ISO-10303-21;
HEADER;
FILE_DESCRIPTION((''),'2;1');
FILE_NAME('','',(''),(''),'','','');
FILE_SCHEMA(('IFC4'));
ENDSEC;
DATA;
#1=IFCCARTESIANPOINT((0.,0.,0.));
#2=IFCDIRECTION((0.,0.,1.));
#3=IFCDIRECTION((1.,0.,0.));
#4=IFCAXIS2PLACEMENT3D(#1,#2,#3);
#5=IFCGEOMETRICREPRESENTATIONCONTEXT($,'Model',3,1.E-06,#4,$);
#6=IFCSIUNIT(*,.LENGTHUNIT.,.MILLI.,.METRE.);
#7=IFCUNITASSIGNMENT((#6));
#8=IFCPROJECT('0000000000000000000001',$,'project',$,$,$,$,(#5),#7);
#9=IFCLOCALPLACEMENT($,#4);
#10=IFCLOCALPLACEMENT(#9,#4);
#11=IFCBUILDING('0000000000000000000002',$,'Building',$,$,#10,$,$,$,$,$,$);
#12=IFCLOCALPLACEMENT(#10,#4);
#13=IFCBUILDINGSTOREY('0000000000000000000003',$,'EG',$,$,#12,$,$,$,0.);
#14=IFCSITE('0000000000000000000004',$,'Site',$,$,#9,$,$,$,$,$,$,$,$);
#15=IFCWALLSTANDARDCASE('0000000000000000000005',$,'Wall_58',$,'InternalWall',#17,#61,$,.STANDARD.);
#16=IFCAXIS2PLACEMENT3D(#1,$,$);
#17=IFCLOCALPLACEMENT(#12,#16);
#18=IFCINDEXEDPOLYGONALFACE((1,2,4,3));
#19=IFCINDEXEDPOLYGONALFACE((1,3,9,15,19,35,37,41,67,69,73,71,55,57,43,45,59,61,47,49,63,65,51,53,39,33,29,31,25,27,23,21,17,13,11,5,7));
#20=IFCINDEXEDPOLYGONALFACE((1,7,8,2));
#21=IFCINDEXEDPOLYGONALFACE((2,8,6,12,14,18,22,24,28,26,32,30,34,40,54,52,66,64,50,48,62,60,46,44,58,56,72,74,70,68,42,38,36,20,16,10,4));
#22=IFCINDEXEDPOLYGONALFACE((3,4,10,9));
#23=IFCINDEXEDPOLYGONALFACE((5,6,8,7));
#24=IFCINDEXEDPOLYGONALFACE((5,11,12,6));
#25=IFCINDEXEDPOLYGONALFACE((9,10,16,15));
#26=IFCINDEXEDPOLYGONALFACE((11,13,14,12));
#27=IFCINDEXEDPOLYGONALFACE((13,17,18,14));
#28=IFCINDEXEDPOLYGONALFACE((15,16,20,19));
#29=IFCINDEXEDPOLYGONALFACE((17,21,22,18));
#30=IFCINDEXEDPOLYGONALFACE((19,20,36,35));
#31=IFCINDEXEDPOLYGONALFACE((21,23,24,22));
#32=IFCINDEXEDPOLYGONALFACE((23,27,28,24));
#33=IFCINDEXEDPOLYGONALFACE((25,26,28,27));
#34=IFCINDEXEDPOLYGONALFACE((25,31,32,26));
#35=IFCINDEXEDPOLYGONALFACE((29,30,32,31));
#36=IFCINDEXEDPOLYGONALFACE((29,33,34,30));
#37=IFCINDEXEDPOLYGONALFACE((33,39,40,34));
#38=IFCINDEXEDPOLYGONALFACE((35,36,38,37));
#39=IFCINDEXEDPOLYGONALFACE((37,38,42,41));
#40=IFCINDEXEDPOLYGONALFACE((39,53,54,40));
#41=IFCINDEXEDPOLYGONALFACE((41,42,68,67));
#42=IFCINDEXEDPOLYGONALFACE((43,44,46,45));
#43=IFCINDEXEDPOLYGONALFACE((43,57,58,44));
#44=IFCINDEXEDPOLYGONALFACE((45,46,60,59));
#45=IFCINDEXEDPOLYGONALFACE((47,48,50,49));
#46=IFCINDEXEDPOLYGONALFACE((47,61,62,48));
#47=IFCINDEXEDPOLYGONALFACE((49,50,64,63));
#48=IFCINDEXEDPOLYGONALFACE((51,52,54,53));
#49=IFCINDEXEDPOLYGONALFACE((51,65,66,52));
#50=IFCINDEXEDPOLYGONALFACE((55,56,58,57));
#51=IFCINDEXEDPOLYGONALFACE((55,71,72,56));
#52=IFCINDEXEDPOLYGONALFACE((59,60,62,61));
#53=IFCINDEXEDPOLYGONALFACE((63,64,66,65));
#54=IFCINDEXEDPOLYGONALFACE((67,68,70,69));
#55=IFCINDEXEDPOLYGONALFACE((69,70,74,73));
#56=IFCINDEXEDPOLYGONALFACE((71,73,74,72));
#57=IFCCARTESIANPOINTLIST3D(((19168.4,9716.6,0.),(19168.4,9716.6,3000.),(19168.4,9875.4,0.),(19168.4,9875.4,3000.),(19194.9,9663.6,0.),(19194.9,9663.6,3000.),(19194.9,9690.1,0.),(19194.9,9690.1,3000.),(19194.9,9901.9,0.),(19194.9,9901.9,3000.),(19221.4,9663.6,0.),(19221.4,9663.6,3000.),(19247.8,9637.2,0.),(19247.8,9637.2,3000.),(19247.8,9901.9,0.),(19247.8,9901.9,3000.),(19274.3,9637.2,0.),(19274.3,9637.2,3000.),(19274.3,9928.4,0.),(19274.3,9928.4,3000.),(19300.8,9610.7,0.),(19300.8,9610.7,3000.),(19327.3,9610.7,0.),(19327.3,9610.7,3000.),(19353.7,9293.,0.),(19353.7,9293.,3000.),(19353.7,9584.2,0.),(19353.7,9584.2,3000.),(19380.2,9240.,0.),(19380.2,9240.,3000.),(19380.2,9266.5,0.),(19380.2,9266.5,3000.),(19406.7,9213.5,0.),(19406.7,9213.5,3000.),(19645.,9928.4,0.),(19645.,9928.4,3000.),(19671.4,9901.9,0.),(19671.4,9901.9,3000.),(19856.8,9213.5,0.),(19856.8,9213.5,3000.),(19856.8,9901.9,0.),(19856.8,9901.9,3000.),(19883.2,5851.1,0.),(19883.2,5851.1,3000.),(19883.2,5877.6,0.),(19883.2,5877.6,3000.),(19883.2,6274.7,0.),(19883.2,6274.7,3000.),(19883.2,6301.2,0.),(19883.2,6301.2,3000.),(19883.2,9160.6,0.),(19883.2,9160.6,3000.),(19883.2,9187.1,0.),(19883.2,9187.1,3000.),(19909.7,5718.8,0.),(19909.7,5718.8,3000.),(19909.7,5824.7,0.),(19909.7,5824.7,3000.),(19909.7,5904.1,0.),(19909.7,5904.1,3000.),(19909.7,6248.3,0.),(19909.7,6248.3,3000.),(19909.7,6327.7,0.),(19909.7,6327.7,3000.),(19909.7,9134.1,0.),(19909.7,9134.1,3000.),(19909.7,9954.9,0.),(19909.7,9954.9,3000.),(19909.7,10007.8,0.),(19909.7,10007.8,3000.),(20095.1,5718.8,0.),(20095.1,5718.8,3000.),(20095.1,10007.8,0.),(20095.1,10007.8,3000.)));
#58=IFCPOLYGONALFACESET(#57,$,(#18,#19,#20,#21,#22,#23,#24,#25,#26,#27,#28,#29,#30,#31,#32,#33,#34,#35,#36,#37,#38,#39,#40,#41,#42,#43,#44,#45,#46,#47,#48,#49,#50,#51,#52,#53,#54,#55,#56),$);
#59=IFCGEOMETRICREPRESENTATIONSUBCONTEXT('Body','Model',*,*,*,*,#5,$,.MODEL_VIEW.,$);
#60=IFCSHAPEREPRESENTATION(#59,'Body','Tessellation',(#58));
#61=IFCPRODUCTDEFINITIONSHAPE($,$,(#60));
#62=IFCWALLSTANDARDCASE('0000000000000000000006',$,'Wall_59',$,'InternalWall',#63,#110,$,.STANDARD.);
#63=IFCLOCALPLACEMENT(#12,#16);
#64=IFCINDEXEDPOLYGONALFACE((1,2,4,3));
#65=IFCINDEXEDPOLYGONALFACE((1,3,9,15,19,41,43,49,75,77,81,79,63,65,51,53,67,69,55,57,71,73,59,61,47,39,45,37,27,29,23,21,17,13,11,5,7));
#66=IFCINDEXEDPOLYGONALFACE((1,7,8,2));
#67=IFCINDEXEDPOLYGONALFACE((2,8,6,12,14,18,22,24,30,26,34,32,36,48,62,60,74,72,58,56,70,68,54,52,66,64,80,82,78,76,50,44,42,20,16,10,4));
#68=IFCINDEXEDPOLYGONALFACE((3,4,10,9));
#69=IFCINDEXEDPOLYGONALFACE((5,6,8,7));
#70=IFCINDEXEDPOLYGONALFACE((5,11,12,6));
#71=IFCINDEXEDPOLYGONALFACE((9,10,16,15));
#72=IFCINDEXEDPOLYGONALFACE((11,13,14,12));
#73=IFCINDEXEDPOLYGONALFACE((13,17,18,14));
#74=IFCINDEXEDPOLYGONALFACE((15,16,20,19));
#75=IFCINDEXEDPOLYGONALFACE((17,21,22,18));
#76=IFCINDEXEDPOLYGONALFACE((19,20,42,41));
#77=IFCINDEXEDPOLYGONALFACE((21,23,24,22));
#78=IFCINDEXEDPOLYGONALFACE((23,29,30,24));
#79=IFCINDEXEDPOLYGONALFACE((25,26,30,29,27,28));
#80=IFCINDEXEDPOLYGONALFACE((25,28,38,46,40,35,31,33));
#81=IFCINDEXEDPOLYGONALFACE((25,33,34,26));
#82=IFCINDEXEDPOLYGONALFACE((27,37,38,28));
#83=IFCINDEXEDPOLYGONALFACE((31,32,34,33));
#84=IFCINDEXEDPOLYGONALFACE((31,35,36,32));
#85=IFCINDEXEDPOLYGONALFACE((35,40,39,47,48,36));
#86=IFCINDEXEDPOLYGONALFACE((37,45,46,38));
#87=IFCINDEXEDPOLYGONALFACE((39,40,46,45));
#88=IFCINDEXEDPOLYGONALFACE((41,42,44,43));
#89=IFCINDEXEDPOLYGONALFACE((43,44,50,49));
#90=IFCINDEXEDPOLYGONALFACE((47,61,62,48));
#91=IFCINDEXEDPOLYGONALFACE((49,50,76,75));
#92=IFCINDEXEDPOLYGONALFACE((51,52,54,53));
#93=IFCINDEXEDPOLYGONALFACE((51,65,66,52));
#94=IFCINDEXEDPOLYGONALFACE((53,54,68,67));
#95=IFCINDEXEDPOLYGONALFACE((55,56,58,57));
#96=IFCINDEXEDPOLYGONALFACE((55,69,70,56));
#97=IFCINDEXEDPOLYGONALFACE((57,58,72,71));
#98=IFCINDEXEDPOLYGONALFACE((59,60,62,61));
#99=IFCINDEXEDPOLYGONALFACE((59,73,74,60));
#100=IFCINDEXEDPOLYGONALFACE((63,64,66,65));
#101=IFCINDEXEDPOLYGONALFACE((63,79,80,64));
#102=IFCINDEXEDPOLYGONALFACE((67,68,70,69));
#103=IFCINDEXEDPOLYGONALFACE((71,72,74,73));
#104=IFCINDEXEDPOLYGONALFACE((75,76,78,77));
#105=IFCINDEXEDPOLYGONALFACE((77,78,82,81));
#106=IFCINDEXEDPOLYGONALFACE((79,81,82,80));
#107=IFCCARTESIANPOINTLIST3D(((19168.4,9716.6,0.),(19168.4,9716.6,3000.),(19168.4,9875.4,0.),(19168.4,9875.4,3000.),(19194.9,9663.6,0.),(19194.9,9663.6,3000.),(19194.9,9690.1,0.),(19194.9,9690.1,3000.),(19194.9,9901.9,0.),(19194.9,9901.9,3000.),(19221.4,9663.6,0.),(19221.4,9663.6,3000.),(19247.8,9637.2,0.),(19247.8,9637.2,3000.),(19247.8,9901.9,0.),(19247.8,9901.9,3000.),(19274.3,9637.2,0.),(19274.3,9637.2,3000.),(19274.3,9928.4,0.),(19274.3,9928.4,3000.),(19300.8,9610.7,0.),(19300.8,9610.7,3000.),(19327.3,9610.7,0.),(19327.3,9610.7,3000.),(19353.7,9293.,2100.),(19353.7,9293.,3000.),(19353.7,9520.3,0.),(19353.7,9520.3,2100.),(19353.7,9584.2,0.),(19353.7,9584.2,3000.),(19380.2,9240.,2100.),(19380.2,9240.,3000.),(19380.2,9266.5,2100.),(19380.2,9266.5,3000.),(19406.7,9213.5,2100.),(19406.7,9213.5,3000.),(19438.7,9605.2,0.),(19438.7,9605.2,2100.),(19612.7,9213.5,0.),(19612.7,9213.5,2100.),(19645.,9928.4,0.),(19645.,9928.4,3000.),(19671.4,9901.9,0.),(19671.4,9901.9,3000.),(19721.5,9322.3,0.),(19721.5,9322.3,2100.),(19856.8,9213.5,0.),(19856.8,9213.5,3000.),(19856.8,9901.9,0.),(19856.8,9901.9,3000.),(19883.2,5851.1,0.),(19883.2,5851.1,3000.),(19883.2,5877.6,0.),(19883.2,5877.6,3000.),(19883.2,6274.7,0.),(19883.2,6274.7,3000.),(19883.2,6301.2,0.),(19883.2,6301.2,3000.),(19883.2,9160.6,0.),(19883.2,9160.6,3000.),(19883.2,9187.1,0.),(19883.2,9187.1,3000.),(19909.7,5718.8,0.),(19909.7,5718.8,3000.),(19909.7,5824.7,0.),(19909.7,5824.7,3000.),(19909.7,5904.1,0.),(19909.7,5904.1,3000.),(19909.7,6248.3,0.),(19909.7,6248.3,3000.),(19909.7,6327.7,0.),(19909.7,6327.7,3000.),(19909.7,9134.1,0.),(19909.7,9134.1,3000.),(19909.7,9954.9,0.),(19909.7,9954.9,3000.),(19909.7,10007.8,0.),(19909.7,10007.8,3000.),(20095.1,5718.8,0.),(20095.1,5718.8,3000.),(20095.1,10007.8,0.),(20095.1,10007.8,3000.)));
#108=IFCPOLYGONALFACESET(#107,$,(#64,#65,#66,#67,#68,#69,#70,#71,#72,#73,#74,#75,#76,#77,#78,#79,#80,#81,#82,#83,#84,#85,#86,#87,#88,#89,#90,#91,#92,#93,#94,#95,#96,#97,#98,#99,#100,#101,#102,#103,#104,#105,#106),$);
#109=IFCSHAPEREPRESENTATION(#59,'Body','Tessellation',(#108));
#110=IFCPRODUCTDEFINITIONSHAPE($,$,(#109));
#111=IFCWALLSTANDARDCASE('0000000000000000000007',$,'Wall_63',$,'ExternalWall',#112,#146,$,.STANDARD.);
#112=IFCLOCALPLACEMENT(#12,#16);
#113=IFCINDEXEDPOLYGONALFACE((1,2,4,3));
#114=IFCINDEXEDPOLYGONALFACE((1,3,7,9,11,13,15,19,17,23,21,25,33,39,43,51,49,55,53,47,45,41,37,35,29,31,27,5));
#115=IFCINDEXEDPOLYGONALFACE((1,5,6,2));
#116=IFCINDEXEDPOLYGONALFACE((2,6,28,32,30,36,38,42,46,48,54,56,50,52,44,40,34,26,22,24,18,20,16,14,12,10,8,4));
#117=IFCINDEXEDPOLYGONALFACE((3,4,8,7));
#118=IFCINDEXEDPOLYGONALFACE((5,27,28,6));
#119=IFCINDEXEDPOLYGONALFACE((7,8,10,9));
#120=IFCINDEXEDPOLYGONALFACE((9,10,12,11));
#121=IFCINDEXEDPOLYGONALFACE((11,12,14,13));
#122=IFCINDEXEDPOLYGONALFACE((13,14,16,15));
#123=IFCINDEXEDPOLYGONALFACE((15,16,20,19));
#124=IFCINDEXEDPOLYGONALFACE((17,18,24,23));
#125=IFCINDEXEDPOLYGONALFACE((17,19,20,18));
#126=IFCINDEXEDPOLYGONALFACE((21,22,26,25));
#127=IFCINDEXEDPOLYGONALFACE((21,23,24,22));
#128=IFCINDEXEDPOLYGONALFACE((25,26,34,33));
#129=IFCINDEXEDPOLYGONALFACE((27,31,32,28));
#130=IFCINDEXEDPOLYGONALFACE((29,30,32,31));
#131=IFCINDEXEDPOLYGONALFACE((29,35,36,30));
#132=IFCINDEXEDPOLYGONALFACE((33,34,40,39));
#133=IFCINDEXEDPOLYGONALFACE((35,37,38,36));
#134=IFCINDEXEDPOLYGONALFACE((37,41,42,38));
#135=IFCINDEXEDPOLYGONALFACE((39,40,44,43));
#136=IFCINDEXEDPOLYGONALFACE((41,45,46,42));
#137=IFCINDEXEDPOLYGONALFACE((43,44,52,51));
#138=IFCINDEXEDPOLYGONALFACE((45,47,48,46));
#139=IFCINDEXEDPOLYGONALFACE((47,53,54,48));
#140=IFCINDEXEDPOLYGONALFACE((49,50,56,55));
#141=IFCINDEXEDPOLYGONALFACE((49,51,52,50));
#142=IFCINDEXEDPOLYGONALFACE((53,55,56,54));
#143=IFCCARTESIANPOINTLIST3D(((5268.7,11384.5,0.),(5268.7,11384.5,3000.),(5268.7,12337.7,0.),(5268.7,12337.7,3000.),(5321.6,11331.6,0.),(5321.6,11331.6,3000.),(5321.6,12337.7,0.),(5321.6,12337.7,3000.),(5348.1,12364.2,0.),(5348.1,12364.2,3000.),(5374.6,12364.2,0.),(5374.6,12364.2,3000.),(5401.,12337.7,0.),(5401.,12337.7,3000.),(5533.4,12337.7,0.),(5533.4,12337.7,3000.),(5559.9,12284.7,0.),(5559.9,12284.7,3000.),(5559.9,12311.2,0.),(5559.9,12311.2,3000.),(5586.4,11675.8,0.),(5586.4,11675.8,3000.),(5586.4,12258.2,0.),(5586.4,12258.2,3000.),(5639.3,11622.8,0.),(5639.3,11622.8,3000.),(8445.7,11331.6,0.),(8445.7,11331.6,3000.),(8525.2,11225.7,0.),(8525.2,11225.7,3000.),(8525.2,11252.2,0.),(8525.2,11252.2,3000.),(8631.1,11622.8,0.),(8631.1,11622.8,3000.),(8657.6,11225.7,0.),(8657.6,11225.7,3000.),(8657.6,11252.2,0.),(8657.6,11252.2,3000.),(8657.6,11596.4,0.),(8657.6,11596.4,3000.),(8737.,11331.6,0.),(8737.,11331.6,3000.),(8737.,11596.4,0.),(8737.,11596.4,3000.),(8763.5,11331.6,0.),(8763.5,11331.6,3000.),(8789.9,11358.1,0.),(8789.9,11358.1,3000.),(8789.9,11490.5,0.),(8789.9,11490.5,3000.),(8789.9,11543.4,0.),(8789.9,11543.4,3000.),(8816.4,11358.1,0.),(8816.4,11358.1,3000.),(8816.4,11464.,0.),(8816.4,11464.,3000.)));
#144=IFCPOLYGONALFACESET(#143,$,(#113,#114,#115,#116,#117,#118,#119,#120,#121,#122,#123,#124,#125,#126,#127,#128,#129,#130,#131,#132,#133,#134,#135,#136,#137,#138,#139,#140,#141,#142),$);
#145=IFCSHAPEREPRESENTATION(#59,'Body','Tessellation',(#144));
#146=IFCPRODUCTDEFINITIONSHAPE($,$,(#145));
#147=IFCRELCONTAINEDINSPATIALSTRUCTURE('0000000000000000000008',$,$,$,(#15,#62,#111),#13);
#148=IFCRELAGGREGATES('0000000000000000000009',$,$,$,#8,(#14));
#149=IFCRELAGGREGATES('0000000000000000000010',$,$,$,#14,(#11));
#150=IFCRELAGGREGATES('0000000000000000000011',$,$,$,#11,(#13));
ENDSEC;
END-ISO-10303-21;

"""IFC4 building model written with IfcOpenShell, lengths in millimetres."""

from ifc_helpers import new_model, si_unit, frame, origin_with_axes, place, context, subcontext, project, spatial, polyline, rectangle, outline, extrude, element, save


model = new_model("IFC4")

# Units and contexts
model_context = context("Model", 3, precision=1e-06, world=origin_with_axes())
body_context = subcontext(model_context, "Body", "Model", "MODEL_VIEW")
ifc_project = project(units=[si_unit("LENGTHUNIT", "METRE", prefix="MILLI")], contexts=[model_context])

# Site, building, storey
site_placement = place(None, origin_with_axes())
site = spatial("IfcSite", under=ifc_project, at=site_placement, Name="Site")
building_placement = place(site_placement, origin_with_axes())
building = spatial("IfcBuilding", under=site, at=building_placement, Name="Building")
storey_placement = place(building_placement, origin_with_axes())
storey = spatial("IfcBuildingStorey", under=building, at=storey_placement, Name="EG", Elevation=0.0)

# Wall
wall_1_placement = place(storey_placement, origin_with_axes())
element("IfcWallStandardCase", 1, at=wall_1_placement, inside=storey, Name="Wall_58", ObjectType="InternalWall", PredefinedType="STANDARD", context=body_context, shape_type="SweptSolid", body=[
    extrude(outline(polyline([(19909.7, 5718.8, 0.0), (19909.7, 5824.7, 0.0), (19883.2, 5851.1, 0.0), (19883.2, 5877.6, 0.0), (19909.7, 5904.1, 0.0), (19909.7, 6248.3, 0.0), (19883.2, 6274.7, 0.0), (19883.2, 6301.2, 0.0), (19909.7, 6327.7, 0.0), (19909.7, 9134.1, 0.0), (19883.2, 9160.6, 0.0), (19883.2, 9187.1, 0.0), (19856.8, 9213.5, 0.0), (19406.7, 9213.5, 0.0), (19380.2, 9240.0, 0.0), (19380.2, 9266.5, 0.0), (19353.7, 9293.0, 0.0), (19353.7, 9584.2, 0.0), (19327.3, 9610.7, 0.0), (19300.8, 9610.7, 0.0), (19274.3, 9637.2, 0.0), (19247.8, 9637.2, 0.0), (19221.4, 9663.6, 0.0), (19194.9, 9663.6, 0.0), (19194.9, 9690.1, 0.0), (19168.4, 9716.6, 0.0), (19168.4, 9875.4, 0.0), (19194.9, 9901.9, 0.0), (19247.8, 9901.9, 0.0), (19274.3, 9928.4, 0.0), (19645.0, 9928.4, 0.0), (19671.4, 9901.9, 0.0), (19856.8, 9901.9, 0.0), (19909.7, 9954.9, 0.0), (19909.7, 10007.8, 0.0), (20095.1, 10007.8, 0.0), (20095.1, 5718.8, 0.0), (19909.7, 5718.8, 0.0)])), origin_with_axes(), (0.0, 0.0, 1.0), 3000.0),
])

# Wall, opening
wall_2_placement = place(storey_placement, origin_with_axes())
wall_2 = element("IfcWallStandardCase", 2, at=wall_2_placement, inside=storey, Name="Wall_59", ObjectType="InternalWall", PredefinedType="STANDARD", context=body_context, shape_type="SweptSolid", body=[
    extrude(outline(polyline([(19909.7, 5718.8, 0.0), (19909.7, 5824.7, 0.0), (19883.2, 5851.1, 0.0), (19883.2, 5877.6, 0.0), (19909.7, 5904.1, 0.0), (19909.7, 6248.3, 0.0), (19883.2, 6274.7, 0.0), (19883.2, 6301.2, 0.0), (19909.7, 6327.7, 0.0), (19909.7, 9134.1, 0.0), (19883.2, 9160.6, 0.0), (19883.2, 9187.1, 0.0), (19856.8, 9213.5, 0.0), (19406.7, 9213.5, 0.0), (19380.2, 9240.0, 0.0), (19380.2, 9266.5, 0.0), (19353.7, 9293.0, 0.0), (19353.7, 9584.2, 0.0), (19327.3, 9610.7, 0.0), (19300.8, 9610.7, 0.0), (19274.3, 9637.2, 0.0), (19247.8, 9637.2, 0.0), (19221.4, 9663.6, 0.0), (19194.9, 9663.6, 0.0), (19194.9, 9690.1, 0.0), (19168.4, 9716.6, 0.0), (19168.4, 9875.4, 0.0), (19194.9, 9901.9, 0.0), (19247.8, 9901.9, 0.0), (19274.3, 9928.4, 0.0), (19645.0, 9928.4, 0.0), (19671.4, 9901.9, 0.0), (19856.8, 9901.9, 0.0), (19909.7, 9954.9, 0.0), (19909.7, 10007.8, 0.0), (20095.1, 10007.8, 0.0), (20095.1, 5718.8, 0.0), (19909.7, 5718.8, 0.0)])), origin_with_axes(), (0.0, 0.0, 1.0), 3000.0),
])
opening_1_placement = place(wall_2_placement, origin_with_axes())
element("IfcOpeningElement", 3, at=opening_1_placement, inside=storey, cuts=wall_2, context=body_context, shape_type="SweptSolid", body=[
    extrude(rectangle(XDim=1048.4, YDim=400.0), frame((19209.4, 9093.1, 0.0), z_axis=(0.0, 0.0, 1.0), x_axis=(-0.707107, -0.707107, 0.0)), (0.0, 0.0, 1.0), 2100.0),
])

# Wall
wall_3_placement = place(storey_placement, origin_with_axes())
element("IfcWallStandardCase", 4, at=wall_3_placement, inside=storey, Name="Wall_63", ObjectType="ExternalWall", PredefinedType="STANDARD", context=body_context, shape_type="SweptSolid", body=[
    extrude(outline(polyline([(8525.2, 11225.7, 0.0), (8525.2, 11252.2, 0.0), (8445.7, 11331.6, 0.0), (5321.6, 11331.6, 0.0), (5268.7, 11384.5, 0.0), (5268.7, 12337.7, 0.0), (5321.6, 12337.7, 0.0), (5348.1, 12364.2, 0.0), (5374.6, 12364.2, 0.0), (5401.0, 12337.7, 0.0), (5533.4, 12337.7, 0.0), (5559.9, 12311.2, 0.0), (5559.9, 12284.7, 0.0), (5586.4, 12258.2, 0.0), (5586.4, 11675.8, 0.0), (5639.3, 11622.8, 0.0), (8631.1, 11622.8, 0.0), (8657.6, 11596.4, 0.0), (8737.0, 11596.4, 0.0), (8789.9, 11543.4, 0.0), (8789.9, 11490.5, 0.0), (8816.4, 11464.0, 0.0), (8816.4, 11358.1, 0.0), (8789.9, 11358.1, 0.0), (8763.5, 11331.6, 0.0), (8737.0, 11331.6, 0.0), (8657.6, 11252.2, 0.0), (8657.6, 11225.7, 0.0), (8525.2, 11225.7, 0.0)])), origin_with_axes(), (0.0, 0.0, 1.0), 3000.0),
])

save(model, "model.ifc")
